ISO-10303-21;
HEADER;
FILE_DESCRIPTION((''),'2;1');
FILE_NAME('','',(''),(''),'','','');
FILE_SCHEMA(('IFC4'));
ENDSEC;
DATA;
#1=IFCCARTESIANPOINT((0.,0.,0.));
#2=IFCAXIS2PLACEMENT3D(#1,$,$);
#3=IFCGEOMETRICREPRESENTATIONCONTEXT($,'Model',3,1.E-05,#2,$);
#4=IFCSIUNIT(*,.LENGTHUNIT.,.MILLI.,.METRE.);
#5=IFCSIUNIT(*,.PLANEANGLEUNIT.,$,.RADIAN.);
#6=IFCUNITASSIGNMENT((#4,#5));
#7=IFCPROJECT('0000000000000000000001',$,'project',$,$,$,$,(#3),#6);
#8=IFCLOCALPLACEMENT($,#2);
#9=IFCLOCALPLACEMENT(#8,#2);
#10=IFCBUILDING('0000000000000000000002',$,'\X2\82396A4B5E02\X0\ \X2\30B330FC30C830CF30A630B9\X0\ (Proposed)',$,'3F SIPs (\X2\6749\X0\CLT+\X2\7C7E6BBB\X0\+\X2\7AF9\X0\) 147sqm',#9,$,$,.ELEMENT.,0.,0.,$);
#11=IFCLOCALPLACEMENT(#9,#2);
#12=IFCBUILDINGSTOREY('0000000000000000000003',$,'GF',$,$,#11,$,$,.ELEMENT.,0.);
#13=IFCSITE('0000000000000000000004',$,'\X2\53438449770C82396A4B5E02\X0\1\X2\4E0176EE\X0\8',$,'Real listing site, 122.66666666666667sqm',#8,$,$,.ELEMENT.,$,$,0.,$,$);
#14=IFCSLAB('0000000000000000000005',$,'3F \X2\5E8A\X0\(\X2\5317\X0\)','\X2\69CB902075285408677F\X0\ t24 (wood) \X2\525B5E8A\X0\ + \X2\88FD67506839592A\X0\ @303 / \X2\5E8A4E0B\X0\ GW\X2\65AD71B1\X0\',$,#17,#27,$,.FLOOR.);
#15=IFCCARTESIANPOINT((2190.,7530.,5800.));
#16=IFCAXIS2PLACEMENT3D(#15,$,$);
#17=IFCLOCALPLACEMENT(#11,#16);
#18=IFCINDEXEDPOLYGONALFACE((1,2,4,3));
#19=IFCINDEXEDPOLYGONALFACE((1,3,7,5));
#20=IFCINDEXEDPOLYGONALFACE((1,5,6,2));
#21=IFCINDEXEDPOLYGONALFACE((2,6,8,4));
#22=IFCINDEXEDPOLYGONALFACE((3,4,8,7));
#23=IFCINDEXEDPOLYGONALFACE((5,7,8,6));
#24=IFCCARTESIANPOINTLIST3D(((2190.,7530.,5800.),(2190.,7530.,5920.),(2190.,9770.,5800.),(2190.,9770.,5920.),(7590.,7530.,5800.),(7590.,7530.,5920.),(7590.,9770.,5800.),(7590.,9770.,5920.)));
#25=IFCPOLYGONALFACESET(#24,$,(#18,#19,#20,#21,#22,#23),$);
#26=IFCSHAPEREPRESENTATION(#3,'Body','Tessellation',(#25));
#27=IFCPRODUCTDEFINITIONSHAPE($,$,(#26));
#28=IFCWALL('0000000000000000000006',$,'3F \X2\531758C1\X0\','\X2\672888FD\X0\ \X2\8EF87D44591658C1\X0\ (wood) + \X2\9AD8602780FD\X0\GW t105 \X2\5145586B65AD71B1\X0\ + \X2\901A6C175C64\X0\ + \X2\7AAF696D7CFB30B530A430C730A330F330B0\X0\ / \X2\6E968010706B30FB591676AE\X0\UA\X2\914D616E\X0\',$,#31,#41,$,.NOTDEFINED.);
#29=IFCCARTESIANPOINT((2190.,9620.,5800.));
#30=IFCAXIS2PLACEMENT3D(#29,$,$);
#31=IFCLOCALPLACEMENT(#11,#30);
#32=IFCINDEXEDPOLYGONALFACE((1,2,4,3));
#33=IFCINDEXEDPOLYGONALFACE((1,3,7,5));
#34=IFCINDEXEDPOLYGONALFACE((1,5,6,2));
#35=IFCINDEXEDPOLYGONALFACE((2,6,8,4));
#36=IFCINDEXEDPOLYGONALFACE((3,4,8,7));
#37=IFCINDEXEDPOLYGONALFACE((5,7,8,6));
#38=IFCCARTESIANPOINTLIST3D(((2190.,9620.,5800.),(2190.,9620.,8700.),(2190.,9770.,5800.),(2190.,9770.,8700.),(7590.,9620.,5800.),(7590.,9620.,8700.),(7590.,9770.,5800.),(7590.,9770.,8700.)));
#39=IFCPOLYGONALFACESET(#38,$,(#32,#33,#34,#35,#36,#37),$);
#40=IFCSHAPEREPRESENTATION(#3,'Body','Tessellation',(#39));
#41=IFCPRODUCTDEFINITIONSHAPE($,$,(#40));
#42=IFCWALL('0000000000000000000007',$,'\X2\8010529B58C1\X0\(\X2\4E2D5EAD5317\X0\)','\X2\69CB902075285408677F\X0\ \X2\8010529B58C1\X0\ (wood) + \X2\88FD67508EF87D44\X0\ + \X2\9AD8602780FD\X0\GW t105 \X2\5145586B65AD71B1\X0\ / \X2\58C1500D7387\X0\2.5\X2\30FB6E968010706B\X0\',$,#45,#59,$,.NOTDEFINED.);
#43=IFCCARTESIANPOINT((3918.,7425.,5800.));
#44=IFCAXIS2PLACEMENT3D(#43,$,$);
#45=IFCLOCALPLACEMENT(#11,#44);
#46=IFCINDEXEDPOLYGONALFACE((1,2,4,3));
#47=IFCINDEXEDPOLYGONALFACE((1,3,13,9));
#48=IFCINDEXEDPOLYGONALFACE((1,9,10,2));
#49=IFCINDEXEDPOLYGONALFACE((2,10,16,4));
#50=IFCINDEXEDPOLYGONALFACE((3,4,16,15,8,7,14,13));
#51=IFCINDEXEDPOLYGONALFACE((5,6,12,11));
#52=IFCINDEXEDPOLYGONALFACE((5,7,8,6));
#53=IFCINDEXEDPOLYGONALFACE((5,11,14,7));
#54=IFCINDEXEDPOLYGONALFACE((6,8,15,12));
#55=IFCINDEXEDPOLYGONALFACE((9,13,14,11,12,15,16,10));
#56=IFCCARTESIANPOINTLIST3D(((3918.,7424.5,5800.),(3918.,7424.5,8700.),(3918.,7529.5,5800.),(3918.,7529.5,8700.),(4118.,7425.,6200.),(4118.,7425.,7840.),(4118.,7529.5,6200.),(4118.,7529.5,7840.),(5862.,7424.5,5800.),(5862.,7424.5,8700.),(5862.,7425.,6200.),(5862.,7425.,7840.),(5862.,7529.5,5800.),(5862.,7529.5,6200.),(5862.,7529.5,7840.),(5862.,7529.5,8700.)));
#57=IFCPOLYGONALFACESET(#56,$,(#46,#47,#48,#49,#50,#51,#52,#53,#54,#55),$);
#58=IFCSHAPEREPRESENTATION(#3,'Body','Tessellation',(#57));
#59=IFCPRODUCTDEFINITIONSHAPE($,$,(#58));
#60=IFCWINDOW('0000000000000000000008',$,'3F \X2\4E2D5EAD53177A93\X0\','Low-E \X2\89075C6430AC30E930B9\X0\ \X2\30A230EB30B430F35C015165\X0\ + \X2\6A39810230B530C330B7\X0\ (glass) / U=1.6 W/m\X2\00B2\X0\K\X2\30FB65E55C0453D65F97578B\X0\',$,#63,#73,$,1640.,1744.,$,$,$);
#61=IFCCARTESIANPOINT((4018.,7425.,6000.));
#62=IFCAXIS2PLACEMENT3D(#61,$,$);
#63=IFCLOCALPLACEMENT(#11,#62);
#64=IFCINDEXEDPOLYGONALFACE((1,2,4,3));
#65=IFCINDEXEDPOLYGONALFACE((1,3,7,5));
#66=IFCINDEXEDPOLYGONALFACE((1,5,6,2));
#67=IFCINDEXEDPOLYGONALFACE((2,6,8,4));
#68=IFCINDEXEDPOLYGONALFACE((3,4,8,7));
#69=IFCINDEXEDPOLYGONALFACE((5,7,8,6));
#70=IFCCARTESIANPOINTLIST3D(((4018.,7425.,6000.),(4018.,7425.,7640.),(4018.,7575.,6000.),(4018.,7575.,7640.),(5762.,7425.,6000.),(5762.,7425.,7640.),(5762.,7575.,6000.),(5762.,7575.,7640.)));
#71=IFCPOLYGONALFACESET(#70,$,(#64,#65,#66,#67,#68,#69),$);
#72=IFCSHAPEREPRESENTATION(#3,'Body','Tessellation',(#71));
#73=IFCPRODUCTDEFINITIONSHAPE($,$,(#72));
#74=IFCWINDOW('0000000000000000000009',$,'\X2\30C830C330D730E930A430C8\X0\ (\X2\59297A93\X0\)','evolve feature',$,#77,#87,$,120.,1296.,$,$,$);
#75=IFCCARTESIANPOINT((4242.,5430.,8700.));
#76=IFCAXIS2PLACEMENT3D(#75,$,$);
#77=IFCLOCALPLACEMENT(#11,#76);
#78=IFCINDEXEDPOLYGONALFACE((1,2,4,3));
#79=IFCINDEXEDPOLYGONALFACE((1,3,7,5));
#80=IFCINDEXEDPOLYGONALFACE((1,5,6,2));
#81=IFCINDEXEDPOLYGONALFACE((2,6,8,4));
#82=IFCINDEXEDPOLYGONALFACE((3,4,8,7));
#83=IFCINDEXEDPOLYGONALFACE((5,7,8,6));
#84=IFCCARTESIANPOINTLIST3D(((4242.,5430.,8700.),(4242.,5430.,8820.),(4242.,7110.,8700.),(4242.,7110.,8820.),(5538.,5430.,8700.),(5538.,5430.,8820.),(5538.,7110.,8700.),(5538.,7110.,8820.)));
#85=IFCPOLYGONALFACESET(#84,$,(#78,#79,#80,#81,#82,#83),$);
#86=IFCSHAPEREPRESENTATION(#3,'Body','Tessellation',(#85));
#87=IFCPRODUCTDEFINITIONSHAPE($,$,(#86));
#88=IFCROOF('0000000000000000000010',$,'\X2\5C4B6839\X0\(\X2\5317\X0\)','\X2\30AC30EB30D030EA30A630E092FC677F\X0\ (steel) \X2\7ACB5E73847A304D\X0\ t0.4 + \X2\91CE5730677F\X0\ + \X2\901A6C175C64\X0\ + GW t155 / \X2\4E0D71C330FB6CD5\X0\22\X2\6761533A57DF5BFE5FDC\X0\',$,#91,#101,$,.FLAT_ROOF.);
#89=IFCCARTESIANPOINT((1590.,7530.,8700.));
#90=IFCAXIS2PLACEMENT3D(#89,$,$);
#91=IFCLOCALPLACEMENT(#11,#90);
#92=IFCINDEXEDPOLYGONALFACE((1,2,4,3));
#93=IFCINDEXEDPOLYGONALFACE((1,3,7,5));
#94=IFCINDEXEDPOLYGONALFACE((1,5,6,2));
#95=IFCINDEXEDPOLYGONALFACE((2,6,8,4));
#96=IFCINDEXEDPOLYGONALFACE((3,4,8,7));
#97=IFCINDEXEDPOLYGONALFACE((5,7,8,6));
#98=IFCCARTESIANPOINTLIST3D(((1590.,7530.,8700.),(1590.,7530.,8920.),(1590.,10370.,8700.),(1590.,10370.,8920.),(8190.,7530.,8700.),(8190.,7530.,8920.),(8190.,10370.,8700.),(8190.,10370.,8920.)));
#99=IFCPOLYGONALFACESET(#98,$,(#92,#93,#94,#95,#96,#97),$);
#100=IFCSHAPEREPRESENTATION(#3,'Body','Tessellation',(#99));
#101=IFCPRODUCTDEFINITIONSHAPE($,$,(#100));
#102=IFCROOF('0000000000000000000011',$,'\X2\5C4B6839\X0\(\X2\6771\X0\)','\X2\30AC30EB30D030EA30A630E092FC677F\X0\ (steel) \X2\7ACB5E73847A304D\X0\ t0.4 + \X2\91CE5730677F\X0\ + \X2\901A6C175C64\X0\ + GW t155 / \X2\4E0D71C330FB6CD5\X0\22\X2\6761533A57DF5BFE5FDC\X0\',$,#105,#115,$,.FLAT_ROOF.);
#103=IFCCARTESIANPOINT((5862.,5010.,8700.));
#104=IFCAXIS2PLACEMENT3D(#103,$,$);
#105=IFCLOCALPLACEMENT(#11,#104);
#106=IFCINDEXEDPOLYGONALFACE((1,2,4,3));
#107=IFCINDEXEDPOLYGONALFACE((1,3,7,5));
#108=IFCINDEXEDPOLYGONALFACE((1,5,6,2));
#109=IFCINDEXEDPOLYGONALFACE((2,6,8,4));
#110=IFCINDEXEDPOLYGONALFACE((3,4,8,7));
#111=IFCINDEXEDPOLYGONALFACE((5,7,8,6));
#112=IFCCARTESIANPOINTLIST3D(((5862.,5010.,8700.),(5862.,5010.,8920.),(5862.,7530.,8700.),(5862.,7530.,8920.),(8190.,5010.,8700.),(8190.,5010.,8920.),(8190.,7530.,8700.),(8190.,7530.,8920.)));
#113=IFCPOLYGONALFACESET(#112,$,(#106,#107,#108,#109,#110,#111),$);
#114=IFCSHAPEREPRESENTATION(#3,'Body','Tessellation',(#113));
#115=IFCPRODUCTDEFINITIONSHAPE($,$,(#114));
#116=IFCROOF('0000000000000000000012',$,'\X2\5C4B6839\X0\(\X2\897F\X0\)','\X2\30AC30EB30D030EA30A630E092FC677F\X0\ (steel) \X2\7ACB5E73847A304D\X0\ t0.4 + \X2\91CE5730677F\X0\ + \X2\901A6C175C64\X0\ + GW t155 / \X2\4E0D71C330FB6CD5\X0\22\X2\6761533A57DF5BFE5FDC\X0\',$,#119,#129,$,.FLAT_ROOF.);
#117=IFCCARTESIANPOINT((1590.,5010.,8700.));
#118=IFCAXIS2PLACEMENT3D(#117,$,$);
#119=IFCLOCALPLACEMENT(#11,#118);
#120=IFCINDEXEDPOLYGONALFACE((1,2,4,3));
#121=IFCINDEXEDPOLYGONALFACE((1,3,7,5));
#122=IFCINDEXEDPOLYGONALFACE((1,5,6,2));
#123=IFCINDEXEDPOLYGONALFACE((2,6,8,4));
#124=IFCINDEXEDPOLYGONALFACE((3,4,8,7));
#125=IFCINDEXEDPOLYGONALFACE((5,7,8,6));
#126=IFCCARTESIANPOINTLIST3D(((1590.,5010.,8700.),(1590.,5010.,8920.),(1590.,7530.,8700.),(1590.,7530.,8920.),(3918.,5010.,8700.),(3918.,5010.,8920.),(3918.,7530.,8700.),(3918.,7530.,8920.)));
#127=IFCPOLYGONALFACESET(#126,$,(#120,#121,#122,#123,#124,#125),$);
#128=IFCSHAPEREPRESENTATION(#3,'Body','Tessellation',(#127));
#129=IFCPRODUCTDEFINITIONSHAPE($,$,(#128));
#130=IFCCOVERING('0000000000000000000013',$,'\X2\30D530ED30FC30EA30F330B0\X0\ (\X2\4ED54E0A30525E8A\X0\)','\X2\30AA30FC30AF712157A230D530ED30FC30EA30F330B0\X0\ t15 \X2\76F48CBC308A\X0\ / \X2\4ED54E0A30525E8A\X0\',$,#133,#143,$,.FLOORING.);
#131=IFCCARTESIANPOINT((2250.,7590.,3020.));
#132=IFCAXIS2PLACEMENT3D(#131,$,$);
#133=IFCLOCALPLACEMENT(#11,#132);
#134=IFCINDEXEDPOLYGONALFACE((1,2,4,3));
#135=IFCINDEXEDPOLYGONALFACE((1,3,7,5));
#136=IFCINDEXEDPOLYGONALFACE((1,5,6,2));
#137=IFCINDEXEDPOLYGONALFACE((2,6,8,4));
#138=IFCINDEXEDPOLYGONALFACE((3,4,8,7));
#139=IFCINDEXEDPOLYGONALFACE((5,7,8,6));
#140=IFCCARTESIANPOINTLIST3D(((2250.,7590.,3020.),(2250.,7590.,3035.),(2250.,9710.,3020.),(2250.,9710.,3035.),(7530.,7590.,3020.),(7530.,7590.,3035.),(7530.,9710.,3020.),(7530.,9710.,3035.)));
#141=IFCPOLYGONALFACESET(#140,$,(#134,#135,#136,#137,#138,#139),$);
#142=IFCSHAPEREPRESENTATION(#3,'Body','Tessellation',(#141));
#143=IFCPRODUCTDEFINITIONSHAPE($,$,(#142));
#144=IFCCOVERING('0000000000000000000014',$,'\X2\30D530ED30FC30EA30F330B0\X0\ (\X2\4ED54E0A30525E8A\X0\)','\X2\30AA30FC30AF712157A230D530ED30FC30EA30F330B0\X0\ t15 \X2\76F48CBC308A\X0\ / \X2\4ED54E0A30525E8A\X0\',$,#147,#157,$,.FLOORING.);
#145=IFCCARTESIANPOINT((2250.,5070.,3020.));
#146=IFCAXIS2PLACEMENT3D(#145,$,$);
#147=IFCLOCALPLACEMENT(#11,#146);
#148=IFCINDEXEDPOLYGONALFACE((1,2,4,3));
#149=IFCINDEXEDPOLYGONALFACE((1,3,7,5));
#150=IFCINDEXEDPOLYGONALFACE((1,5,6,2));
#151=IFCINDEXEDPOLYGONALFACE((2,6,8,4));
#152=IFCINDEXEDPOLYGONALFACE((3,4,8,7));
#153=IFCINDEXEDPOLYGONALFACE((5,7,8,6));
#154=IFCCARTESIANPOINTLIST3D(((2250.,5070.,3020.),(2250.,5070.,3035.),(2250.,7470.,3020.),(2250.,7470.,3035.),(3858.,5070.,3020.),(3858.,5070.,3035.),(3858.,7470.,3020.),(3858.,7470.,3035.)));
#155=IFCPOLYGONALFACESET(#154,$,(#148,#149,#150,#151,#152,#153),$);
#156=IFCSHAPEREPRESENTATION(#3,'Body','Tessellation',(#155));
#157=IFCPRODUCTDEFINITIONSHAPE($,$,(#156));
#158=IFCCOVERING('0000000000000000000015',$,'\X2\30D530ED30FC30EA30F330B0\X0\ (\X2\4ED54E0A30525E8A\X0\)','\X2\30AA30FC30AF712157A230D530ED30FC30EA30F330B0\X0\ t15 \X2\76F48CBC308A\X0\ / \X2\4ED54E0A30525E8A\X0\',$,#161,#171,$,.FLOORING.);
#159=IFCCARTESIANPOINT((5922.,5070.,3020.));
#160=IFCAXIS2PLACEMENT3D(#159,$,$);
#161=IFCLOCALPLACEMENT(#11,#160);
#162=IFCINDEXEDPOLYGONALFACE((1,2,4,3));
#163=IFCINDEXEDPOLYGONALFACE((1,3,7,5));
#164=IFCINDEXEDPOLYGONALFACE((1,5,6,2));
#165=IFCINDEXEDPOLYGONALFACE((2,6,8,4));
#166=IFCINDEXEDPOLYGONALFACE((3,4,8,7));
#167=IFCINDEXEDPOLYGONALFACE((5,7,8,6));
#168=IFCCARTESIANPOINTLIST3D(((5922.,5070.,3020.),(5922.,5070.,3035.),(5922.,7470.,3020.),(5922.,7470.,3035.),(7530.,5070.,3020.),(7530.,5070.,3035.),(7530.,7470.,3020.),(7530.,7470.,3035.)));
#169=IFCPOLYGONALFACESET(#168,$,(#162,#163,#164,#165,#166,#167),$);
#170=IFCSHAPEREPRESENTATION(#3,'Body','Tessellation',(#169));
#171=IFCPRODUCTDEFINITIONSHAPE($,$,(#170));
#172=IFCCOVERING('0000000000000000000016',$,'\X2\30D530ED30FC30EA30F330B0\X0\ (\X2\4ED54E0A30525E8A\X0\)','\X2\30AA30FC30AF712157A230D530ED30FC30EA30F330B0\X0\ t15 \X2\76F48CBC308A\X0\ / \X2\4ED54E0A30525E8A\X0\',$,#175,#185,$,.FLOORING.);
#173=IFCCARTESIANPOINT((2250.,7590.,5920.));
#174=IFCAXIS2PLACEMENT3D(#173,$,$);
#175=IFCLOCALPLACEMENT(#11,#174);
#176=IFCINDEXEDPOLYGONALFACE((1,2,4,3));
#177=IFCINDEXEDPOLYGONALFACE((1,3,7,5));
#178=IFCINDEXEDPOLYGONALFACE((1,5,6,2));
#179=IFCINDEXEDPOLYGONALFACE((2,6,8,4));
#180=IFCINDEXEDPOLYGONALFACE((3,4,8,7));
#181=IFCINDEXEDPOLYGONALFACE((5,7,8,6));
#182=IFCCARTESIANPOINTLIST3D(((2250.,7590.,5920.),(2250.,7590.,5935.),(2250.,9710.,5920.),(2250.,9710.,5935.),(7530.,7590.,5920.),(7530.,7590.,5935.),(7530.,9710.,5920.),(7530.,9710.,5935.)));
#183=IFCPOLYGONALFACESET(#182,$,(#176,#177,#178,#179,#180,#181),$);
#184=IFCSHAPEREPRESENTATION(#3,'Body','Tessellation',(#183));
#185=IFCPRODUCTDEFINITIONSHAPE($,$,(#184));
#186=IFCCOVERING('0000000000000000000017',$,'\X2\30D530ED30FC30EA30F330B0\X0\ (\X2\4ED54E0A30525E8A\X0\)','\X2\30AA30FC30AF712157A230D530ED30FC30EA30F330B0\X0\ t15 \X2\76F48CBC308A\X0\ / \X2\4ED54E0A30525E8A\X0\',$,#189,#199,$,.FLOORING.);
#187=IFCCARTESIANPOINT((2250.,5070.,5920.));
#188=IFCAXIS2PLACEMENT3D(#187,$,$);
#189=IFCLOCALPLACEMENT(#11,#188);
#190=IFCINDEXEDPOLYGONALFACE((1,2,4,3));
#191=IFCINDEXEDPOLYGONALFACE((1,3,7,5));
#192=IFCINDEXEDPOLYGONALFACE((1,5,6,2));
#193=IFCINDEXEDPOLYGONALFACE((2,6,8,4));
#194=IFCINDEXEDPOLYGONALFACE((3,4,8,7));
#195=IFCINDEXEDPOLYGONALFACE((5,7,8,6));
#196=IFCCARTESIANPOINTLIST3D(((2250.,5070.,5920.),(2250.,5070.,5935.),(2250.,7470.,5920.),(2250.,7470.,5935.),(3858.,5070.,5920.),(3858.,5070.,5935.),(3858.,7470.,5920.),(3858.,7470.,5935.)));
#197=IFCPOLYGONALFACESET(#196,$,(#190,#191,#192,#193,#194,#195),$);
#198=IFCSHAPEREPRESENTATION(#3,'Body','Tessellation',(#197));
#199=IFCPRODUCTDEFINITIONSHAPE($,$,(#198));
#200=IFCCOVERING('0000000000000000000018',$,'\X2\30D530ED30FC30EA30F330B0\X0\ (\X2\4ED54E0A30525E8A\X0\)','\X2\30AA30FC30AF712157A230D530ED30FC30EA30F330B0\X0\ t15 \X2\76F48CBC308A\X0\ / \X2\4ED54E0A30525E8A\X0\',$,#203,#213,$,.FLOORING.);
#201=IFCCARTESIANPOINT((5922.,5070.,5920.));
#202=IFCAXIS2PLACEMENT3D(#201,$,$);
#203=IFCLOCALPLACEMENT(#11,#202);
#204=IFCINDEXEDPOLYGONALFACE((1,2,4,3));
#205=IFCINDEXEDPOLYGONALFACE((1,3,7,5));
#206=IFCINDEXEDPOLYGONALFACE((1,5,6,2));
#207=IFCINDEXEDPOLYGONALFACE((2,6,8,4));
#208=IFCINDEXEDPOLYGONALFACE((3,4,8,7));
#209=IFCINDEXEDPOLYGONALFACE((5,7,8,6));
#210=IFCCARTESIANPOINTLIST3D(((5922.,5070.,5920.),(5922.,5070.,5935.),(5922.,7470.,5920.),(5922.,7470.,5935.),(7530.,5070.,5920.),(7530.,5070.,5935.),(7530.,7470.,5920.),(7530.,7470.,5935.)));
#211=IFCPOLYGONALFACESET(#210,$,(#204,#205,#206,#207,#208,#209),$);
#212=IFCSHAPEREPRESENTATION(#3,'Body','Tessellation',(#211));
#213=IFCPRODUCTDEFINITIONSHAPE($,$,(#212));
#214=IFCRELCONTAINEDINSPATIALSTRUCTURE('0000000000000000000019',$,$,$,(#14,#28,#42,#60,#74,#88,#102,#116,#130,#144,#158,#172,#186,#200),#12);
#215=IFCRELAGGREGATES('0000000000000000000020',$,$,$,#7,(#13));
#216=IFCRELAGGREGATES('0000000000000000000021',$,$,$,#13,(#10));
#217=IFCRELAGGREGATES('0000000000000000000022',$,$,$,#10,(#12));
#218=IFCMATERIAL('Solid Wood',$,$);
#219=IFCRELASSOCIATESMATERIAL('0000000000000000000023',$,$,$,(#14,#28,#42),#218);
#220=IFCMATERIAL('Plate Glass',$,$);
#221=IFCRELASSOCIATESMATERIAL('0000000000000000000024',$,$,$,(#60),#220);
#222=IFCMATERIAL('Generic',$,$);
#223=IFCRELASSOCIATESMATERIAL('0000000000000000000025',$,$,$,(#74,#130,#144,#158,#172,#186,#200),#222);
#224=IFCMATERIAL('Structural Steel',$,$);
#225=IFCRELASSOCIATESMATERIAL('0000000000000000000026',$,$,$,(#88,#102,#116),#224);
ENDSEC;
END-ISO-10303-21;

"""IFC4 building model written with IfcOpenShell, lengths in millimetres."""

from ifc_helpers import new_model, si_unit, frame, frame_2d, origin, place, context, project, spatial, rectangle, extrude, material, element, fill, save


model = new_model("IFC4")

# Units and contexts
model_context = context("Model", 3, precision=1e-05, world=origin())
ifc_project = project(units=[si_unit("LENGTHUNIT", "METRE", prefix="MILLI"), si_unit("PLANEANGLEUNIT", "RADIAN")], contexts=[model_context])

# Site, building, storey
site_placement = place(None, origin())
site = spatial("IfcSite", under=ifc_project, at=site_placement, Name="千葉県船橋市1丁目8", ObjectType="Real listing site, 122.66666666666667sqm", CompositionType="ELEMENT", RefElevation=0.0)
building_placement = place(site_placement, origin())
building = spatial("IfcBuilding", under=site, at=building_placement, Name="船橋市 コートハウス (Proposed)", ObjectType="3F SIPs (杉CLT+籾殻+竹) 147sqm", CompositionType="ELEMENT", ElevationOfRefHeight=0.0, ElevationOfTerrain=0.0)
storey_placement = place(building_placement, origin())
storey = spatial("IfcBuildingStorey", under=building, at=storey_placement, Name="GF", CompositionType="ELEMENT", Elevation=0.0)

# Slab
ifc_material_1 = material(Name="Solid Wood")
slab_placement = place(storey_placement, frame((2190.0, 7530.0, 5800.0)))
element("IfcSlab", 1, at=slab_placement, inside=storey, material=ifc_material_1, Name="3F 床(北)", Description="構造用合板 t24 (wood) 剛床 + 製材根太 @303 / 床下 GW断熱", PredefinedType="FLOOR", context=model_context, shape_type="SweptSolid", body=[
    extrude(rectangle(XDim=5400.0, YDim=2240.0, at=frame_2d((2700.0, 1120.0))), frame((2190.0, 7530.0, 5800.0)), (0.0, 0.0, 1.0), 120.0),
])

# Wall
wall_1_placement = place(storey_placement, frame((2190.0, 9620.0, 5800.0)))
element("IfcWall", 2, at=wall_1_placement, inside=storey, material=ifc_material_1, Name="3F 北壁", Description="木製 軸組外壁 (wood) + 高性能GW t105 充填断熱 + 通気層 + 窯業系サイディング / 準耐火・外皮UA配慮", PredefinedType="NOTDEFINED", context=model_context, shape_type="SweptSolid", body=[
    extrude(rectangle(XDim=5400.0, YDim=150.0, at=frame_2d((2700.0, 75.0))), frame((2190.0, 9620.0, 5800.0)), (0.0, 0.0, 1.0), 2900.0),
])

# Wall, opening, window
wall_2_placement = place(storey_placement, frame((3918.0, 7425.0, 5800.0)))
wall_2 = element("IfcWall", 3, at=wall_2_placement, inside=storey, material=ifc_material_1, Name="耐力壁(中庭北)", Description="構造用合板 耐力壁 (wood) + 製材軸組 + 高性能GW t105 充填断熱 / 壁倍率2.5・準耐火", PredefinedType="NOTDEFINED", context=model_context, shape_type="SweptSolid", body=[
    extrude(rectangle(XDim=1944.0, YDim=105.0, at=frame_2d((972.0, 52.0))), frame((3918.0, 7425.0, 5800.0)), (0.0, 0.0, 1.0), 2900.0),
])
opening_placement = place(storey_placement, frame((4018.0, 7425.0, 6000.0)))
opening = element("IfcOpeningElement", 4, at=opening_placement, cuts=wall_2, PredefinedType="NOTDEFINED", context=model_context, shape_type="SweptSolid", body=[
    extrude(rectangle(XDim=1744.0, YDim=150.0, at=frame_2d((872.0, 75.0))), frame((4018.0, 7425.0, 6000.0)), (0.0, 0.0, 1.0), 1640.0),
])
ifc_material_2 = material(Name="Plate Glass")
window_1_placement = place(storey_placement, frame((4018.0, 7425.0, 6000.0)))
window_1 = element("IfcWindow", 5, at=window_1_placement, inside=storey, material=ifc_material_2, Name="3F 中庭北窓", Description="Low-E 複層ガラス アルゴン封入 + 樹脂サッシ (glass) / U=1.6 W/m²K・日射取得型", OverallHeight=1640.0, OverallWidth=1744.0, context=model_context, shape_type="SweptSolid", body=[
    extrude(rectangle(XDim=1744.0, YDim=150.0, at=frame_2d((872.0, 75.0))), frame((4018.0, 7425.0, 6000.0)), (0.0, 0.0, 1.0), 1640.0),
])
fill(opening, window_1)

# Window
ifc_material_3 = material(Name="Generic")
window_2_placement = place(storey_placement, frame((4242.0, 5430.0, 8700.0)))
element("IfcWindow", 6, at=window_2_placement, inside=storey, material=ifc_material_3, Name="トップライト (天窓)", Description="evolve feature", OverallHeight=120.0, OverallWidth=1296.0, context=model_context, shape_type="SweptSolid", body=[
    extrude(rectangle(XDim=1296.0, YDim=1680.0, at=frame_2d((648.0, 840.0))), frame((4242.0, 5430.0, 8700.0)), (0.0, 0.0, 1.0), 120.0),
])

# Roofs
ifc_material_4 = material(Name="Structural Steel")
roof_1_placement = place(storey_placement, frame((1590.0, 7530.0, 8700.0)))
element("IfcRoof", 7, at=roof_1_placement, inside=storey, material=ifc_material_4, Name="屋根(北)", Description="ガルバリウム鋼板 (steel) 立平葺き t0.4 + 野地板 + 通気層 + GW t155 / 不燃・法22条区域対応", PredefinedType="FLAT_ROOF", context=model_context, shape_type="SweptSolid", body=[
    extrude(rectangle(XDim=6600.0, YDim=2840.0, at=frame_2d((3300.0, 1420.0))), frame((1590.0, 7530.0, 8700.0)), (0.0, 0.0, 1.0), 220.0),
])
roof_2_placement = place(storey_placement, frame((5862.0, 5010.0, 8700.0)))
element("IfcRoof", 8, at=roof_2_placement, inside=storey, material=ifc_material_4, Name="屋根(東)", Description="ガルバリウム鋼板 (steel) 立平葺き t0.4 + 野地板 + 通気層 + GW t155 / 不燃・法22条区域対応", PredefinedType="FLAT_ROOF", context=model_context, shape_type="SweptSolid", body=[
    extrude(rectangle(XDim=2328.0, YDim=2520.0, at=frame_2d((1164.0, 1260.0))), frame((5862.0, 5010.0, 8700.0)), (0.0, 0.0, 1.0), 220.0),
])
roof_3_placement = place(storey_placement, frame((1590.0, 5010.0, 8700.0)))
element("IfcRoof", 9, at=roof_3_placement, inside=storey, material=ifc_material_4, Name="屋根(西)", Description="ガルバリウム鋼板 (steel) 立平葺き t0.4 + 野地板 + 通気層 + GW t155 / 不燃・法22条区域対応", PredefinedType="FLAT_ROOF", context=model_context, shape_type="SweptSolid", body=[
    extrude(rectangle(XDim=2328.0, YDim=2520.0, at=frame_2d((1164.0, 1260.0))), frame((1590.0, 5010.0, 8700.0)), (0.0, 0.0, 1.0), 220.0),
])

# Coverings
covering_1_placement = place(storey_placement, frame((2250.0, 7590.0, 3020.0)))
element("IfcCovering", 10, at=covering_1_placement, inside=storey, material=ifc_material_3, Name="フローリング (仕上げ床)", Description="オーク無垢フローリング t15 直貼り / 仕上げ床", PredefinedType="FLOORING", context=model_context, shape_type="SweptSolid", body=[
    extrude(rectangle(XDim=5280.0, YDim=2120.0, at=frame_2d((2640.0, 1060.0))), frame((2250.0, 7590.0, 3020.0)), (0.0, 0.0, 1.0), 15.0),
])
covering_2_placement = place(storey_placement, frame((2250.0, 5070.0, 3020.0)))
element("IfcCovering", 11, at=covering_2_placement, inside=storey, material=ifc_material_3, Name="フローリング (仕上げ床)", Description="オーク無垢フローリング t15 直貼り / 仕上げ床", PredefinedType="FLOORING", context=model_context, shape_type="SweptSolid", body=[
    extrude(rectangle(XDim=1608.0, YDim=2400.0, at=frame_2d((804.0, 1200.0))), frame((2250.0, 5070.0, 3020.0)), (0.0, 0.0, 1.0), 15.0),
])
covering_3_placement = place(storey_placement, frame((5922.0, 5070.0, 3020.0)))
element("IfcCovering", 12, at=covering_3_placement, inside=storey, material=ifc_material_3, Name="フローリング (仕上げ床)", Description="オーク無垢フローリング t15 直貼り / 仕上げ床", PredefinedType="FLOORING", context=model_context, shape_type="SweptSolid", body=[
    extrude(rectangle(XDim=1608.0, YDim=2400.0, at=frame_2d((804.0, 1200.0))), frame((5922.0, 5070.0, 3020.0)), (0.0, 0.0, 1.0), 15.0),
])
covering_4_placement = place(storey_placement, frame((2250.0, 7590.0, 5920.0)))
element("IfcCovering", 13, at=covering_4_placement, inside=storey, material=ifc_material_3, Name="フローリング (仕上げ床)", Description="オーク無垢フローリング t15 直貼り / 仕上げ床", PredefinedType="FLOORING", context=model_context, shape_type="SweptSolid", body=[
    extrude(rectangle(XDim=5280.0, YDim=2120.0, at=frame_2d((2640.0, 1060.0))), frame((2250.0, 7590.0, 5920.0)), (0.0, 0.0, 1.0), 15.0),
])
covering_5_placement = place(storey_placement, frame((2250.0, 5070.0, 5920.0)))
element("IfcCovering", 14, at=covering_5_placement, inside=storey, material=ifc_material_3, Name="フローリング (仕上げ床)", Description="オーク無垢フローリング t15 直貼り / 仕上げ床", PredefinedType="FLOORING", context=model_context, shape_type="SweptSolid", body=[
    extrude(rectangle(XDim=1608.0, YDim=2400.0, at=frame_2d((804.0, 1200.0))), frame((2250.0, 5070.0, 5920.0)), (0.0, 0.0, 1.0), 15.0),
])
covering_6_placement = place(storey_placement, frame((5922.0, 5070.0, 5920.0)))
element("IfcCovering", 15, at=covering_6_placement, inside=storey, material=ifc_material_3, Name="フローリング (仕上げ床)", Description="オーク無垢フローリング t15 直貼り / 仕上げ床", PredefinedType="FLOORING", context=model_context, shape_type="SweptSolid", body=[
    extrude(rectangle(XDim=1608.0, YDim=2400.0, at=frame_2d((804.0, 1200.0))), frame((5922.0, 5070.0, 5920.0)), (0.0, 0.0, 1.0), 15.0),
])

save(model, "model.ifc")
